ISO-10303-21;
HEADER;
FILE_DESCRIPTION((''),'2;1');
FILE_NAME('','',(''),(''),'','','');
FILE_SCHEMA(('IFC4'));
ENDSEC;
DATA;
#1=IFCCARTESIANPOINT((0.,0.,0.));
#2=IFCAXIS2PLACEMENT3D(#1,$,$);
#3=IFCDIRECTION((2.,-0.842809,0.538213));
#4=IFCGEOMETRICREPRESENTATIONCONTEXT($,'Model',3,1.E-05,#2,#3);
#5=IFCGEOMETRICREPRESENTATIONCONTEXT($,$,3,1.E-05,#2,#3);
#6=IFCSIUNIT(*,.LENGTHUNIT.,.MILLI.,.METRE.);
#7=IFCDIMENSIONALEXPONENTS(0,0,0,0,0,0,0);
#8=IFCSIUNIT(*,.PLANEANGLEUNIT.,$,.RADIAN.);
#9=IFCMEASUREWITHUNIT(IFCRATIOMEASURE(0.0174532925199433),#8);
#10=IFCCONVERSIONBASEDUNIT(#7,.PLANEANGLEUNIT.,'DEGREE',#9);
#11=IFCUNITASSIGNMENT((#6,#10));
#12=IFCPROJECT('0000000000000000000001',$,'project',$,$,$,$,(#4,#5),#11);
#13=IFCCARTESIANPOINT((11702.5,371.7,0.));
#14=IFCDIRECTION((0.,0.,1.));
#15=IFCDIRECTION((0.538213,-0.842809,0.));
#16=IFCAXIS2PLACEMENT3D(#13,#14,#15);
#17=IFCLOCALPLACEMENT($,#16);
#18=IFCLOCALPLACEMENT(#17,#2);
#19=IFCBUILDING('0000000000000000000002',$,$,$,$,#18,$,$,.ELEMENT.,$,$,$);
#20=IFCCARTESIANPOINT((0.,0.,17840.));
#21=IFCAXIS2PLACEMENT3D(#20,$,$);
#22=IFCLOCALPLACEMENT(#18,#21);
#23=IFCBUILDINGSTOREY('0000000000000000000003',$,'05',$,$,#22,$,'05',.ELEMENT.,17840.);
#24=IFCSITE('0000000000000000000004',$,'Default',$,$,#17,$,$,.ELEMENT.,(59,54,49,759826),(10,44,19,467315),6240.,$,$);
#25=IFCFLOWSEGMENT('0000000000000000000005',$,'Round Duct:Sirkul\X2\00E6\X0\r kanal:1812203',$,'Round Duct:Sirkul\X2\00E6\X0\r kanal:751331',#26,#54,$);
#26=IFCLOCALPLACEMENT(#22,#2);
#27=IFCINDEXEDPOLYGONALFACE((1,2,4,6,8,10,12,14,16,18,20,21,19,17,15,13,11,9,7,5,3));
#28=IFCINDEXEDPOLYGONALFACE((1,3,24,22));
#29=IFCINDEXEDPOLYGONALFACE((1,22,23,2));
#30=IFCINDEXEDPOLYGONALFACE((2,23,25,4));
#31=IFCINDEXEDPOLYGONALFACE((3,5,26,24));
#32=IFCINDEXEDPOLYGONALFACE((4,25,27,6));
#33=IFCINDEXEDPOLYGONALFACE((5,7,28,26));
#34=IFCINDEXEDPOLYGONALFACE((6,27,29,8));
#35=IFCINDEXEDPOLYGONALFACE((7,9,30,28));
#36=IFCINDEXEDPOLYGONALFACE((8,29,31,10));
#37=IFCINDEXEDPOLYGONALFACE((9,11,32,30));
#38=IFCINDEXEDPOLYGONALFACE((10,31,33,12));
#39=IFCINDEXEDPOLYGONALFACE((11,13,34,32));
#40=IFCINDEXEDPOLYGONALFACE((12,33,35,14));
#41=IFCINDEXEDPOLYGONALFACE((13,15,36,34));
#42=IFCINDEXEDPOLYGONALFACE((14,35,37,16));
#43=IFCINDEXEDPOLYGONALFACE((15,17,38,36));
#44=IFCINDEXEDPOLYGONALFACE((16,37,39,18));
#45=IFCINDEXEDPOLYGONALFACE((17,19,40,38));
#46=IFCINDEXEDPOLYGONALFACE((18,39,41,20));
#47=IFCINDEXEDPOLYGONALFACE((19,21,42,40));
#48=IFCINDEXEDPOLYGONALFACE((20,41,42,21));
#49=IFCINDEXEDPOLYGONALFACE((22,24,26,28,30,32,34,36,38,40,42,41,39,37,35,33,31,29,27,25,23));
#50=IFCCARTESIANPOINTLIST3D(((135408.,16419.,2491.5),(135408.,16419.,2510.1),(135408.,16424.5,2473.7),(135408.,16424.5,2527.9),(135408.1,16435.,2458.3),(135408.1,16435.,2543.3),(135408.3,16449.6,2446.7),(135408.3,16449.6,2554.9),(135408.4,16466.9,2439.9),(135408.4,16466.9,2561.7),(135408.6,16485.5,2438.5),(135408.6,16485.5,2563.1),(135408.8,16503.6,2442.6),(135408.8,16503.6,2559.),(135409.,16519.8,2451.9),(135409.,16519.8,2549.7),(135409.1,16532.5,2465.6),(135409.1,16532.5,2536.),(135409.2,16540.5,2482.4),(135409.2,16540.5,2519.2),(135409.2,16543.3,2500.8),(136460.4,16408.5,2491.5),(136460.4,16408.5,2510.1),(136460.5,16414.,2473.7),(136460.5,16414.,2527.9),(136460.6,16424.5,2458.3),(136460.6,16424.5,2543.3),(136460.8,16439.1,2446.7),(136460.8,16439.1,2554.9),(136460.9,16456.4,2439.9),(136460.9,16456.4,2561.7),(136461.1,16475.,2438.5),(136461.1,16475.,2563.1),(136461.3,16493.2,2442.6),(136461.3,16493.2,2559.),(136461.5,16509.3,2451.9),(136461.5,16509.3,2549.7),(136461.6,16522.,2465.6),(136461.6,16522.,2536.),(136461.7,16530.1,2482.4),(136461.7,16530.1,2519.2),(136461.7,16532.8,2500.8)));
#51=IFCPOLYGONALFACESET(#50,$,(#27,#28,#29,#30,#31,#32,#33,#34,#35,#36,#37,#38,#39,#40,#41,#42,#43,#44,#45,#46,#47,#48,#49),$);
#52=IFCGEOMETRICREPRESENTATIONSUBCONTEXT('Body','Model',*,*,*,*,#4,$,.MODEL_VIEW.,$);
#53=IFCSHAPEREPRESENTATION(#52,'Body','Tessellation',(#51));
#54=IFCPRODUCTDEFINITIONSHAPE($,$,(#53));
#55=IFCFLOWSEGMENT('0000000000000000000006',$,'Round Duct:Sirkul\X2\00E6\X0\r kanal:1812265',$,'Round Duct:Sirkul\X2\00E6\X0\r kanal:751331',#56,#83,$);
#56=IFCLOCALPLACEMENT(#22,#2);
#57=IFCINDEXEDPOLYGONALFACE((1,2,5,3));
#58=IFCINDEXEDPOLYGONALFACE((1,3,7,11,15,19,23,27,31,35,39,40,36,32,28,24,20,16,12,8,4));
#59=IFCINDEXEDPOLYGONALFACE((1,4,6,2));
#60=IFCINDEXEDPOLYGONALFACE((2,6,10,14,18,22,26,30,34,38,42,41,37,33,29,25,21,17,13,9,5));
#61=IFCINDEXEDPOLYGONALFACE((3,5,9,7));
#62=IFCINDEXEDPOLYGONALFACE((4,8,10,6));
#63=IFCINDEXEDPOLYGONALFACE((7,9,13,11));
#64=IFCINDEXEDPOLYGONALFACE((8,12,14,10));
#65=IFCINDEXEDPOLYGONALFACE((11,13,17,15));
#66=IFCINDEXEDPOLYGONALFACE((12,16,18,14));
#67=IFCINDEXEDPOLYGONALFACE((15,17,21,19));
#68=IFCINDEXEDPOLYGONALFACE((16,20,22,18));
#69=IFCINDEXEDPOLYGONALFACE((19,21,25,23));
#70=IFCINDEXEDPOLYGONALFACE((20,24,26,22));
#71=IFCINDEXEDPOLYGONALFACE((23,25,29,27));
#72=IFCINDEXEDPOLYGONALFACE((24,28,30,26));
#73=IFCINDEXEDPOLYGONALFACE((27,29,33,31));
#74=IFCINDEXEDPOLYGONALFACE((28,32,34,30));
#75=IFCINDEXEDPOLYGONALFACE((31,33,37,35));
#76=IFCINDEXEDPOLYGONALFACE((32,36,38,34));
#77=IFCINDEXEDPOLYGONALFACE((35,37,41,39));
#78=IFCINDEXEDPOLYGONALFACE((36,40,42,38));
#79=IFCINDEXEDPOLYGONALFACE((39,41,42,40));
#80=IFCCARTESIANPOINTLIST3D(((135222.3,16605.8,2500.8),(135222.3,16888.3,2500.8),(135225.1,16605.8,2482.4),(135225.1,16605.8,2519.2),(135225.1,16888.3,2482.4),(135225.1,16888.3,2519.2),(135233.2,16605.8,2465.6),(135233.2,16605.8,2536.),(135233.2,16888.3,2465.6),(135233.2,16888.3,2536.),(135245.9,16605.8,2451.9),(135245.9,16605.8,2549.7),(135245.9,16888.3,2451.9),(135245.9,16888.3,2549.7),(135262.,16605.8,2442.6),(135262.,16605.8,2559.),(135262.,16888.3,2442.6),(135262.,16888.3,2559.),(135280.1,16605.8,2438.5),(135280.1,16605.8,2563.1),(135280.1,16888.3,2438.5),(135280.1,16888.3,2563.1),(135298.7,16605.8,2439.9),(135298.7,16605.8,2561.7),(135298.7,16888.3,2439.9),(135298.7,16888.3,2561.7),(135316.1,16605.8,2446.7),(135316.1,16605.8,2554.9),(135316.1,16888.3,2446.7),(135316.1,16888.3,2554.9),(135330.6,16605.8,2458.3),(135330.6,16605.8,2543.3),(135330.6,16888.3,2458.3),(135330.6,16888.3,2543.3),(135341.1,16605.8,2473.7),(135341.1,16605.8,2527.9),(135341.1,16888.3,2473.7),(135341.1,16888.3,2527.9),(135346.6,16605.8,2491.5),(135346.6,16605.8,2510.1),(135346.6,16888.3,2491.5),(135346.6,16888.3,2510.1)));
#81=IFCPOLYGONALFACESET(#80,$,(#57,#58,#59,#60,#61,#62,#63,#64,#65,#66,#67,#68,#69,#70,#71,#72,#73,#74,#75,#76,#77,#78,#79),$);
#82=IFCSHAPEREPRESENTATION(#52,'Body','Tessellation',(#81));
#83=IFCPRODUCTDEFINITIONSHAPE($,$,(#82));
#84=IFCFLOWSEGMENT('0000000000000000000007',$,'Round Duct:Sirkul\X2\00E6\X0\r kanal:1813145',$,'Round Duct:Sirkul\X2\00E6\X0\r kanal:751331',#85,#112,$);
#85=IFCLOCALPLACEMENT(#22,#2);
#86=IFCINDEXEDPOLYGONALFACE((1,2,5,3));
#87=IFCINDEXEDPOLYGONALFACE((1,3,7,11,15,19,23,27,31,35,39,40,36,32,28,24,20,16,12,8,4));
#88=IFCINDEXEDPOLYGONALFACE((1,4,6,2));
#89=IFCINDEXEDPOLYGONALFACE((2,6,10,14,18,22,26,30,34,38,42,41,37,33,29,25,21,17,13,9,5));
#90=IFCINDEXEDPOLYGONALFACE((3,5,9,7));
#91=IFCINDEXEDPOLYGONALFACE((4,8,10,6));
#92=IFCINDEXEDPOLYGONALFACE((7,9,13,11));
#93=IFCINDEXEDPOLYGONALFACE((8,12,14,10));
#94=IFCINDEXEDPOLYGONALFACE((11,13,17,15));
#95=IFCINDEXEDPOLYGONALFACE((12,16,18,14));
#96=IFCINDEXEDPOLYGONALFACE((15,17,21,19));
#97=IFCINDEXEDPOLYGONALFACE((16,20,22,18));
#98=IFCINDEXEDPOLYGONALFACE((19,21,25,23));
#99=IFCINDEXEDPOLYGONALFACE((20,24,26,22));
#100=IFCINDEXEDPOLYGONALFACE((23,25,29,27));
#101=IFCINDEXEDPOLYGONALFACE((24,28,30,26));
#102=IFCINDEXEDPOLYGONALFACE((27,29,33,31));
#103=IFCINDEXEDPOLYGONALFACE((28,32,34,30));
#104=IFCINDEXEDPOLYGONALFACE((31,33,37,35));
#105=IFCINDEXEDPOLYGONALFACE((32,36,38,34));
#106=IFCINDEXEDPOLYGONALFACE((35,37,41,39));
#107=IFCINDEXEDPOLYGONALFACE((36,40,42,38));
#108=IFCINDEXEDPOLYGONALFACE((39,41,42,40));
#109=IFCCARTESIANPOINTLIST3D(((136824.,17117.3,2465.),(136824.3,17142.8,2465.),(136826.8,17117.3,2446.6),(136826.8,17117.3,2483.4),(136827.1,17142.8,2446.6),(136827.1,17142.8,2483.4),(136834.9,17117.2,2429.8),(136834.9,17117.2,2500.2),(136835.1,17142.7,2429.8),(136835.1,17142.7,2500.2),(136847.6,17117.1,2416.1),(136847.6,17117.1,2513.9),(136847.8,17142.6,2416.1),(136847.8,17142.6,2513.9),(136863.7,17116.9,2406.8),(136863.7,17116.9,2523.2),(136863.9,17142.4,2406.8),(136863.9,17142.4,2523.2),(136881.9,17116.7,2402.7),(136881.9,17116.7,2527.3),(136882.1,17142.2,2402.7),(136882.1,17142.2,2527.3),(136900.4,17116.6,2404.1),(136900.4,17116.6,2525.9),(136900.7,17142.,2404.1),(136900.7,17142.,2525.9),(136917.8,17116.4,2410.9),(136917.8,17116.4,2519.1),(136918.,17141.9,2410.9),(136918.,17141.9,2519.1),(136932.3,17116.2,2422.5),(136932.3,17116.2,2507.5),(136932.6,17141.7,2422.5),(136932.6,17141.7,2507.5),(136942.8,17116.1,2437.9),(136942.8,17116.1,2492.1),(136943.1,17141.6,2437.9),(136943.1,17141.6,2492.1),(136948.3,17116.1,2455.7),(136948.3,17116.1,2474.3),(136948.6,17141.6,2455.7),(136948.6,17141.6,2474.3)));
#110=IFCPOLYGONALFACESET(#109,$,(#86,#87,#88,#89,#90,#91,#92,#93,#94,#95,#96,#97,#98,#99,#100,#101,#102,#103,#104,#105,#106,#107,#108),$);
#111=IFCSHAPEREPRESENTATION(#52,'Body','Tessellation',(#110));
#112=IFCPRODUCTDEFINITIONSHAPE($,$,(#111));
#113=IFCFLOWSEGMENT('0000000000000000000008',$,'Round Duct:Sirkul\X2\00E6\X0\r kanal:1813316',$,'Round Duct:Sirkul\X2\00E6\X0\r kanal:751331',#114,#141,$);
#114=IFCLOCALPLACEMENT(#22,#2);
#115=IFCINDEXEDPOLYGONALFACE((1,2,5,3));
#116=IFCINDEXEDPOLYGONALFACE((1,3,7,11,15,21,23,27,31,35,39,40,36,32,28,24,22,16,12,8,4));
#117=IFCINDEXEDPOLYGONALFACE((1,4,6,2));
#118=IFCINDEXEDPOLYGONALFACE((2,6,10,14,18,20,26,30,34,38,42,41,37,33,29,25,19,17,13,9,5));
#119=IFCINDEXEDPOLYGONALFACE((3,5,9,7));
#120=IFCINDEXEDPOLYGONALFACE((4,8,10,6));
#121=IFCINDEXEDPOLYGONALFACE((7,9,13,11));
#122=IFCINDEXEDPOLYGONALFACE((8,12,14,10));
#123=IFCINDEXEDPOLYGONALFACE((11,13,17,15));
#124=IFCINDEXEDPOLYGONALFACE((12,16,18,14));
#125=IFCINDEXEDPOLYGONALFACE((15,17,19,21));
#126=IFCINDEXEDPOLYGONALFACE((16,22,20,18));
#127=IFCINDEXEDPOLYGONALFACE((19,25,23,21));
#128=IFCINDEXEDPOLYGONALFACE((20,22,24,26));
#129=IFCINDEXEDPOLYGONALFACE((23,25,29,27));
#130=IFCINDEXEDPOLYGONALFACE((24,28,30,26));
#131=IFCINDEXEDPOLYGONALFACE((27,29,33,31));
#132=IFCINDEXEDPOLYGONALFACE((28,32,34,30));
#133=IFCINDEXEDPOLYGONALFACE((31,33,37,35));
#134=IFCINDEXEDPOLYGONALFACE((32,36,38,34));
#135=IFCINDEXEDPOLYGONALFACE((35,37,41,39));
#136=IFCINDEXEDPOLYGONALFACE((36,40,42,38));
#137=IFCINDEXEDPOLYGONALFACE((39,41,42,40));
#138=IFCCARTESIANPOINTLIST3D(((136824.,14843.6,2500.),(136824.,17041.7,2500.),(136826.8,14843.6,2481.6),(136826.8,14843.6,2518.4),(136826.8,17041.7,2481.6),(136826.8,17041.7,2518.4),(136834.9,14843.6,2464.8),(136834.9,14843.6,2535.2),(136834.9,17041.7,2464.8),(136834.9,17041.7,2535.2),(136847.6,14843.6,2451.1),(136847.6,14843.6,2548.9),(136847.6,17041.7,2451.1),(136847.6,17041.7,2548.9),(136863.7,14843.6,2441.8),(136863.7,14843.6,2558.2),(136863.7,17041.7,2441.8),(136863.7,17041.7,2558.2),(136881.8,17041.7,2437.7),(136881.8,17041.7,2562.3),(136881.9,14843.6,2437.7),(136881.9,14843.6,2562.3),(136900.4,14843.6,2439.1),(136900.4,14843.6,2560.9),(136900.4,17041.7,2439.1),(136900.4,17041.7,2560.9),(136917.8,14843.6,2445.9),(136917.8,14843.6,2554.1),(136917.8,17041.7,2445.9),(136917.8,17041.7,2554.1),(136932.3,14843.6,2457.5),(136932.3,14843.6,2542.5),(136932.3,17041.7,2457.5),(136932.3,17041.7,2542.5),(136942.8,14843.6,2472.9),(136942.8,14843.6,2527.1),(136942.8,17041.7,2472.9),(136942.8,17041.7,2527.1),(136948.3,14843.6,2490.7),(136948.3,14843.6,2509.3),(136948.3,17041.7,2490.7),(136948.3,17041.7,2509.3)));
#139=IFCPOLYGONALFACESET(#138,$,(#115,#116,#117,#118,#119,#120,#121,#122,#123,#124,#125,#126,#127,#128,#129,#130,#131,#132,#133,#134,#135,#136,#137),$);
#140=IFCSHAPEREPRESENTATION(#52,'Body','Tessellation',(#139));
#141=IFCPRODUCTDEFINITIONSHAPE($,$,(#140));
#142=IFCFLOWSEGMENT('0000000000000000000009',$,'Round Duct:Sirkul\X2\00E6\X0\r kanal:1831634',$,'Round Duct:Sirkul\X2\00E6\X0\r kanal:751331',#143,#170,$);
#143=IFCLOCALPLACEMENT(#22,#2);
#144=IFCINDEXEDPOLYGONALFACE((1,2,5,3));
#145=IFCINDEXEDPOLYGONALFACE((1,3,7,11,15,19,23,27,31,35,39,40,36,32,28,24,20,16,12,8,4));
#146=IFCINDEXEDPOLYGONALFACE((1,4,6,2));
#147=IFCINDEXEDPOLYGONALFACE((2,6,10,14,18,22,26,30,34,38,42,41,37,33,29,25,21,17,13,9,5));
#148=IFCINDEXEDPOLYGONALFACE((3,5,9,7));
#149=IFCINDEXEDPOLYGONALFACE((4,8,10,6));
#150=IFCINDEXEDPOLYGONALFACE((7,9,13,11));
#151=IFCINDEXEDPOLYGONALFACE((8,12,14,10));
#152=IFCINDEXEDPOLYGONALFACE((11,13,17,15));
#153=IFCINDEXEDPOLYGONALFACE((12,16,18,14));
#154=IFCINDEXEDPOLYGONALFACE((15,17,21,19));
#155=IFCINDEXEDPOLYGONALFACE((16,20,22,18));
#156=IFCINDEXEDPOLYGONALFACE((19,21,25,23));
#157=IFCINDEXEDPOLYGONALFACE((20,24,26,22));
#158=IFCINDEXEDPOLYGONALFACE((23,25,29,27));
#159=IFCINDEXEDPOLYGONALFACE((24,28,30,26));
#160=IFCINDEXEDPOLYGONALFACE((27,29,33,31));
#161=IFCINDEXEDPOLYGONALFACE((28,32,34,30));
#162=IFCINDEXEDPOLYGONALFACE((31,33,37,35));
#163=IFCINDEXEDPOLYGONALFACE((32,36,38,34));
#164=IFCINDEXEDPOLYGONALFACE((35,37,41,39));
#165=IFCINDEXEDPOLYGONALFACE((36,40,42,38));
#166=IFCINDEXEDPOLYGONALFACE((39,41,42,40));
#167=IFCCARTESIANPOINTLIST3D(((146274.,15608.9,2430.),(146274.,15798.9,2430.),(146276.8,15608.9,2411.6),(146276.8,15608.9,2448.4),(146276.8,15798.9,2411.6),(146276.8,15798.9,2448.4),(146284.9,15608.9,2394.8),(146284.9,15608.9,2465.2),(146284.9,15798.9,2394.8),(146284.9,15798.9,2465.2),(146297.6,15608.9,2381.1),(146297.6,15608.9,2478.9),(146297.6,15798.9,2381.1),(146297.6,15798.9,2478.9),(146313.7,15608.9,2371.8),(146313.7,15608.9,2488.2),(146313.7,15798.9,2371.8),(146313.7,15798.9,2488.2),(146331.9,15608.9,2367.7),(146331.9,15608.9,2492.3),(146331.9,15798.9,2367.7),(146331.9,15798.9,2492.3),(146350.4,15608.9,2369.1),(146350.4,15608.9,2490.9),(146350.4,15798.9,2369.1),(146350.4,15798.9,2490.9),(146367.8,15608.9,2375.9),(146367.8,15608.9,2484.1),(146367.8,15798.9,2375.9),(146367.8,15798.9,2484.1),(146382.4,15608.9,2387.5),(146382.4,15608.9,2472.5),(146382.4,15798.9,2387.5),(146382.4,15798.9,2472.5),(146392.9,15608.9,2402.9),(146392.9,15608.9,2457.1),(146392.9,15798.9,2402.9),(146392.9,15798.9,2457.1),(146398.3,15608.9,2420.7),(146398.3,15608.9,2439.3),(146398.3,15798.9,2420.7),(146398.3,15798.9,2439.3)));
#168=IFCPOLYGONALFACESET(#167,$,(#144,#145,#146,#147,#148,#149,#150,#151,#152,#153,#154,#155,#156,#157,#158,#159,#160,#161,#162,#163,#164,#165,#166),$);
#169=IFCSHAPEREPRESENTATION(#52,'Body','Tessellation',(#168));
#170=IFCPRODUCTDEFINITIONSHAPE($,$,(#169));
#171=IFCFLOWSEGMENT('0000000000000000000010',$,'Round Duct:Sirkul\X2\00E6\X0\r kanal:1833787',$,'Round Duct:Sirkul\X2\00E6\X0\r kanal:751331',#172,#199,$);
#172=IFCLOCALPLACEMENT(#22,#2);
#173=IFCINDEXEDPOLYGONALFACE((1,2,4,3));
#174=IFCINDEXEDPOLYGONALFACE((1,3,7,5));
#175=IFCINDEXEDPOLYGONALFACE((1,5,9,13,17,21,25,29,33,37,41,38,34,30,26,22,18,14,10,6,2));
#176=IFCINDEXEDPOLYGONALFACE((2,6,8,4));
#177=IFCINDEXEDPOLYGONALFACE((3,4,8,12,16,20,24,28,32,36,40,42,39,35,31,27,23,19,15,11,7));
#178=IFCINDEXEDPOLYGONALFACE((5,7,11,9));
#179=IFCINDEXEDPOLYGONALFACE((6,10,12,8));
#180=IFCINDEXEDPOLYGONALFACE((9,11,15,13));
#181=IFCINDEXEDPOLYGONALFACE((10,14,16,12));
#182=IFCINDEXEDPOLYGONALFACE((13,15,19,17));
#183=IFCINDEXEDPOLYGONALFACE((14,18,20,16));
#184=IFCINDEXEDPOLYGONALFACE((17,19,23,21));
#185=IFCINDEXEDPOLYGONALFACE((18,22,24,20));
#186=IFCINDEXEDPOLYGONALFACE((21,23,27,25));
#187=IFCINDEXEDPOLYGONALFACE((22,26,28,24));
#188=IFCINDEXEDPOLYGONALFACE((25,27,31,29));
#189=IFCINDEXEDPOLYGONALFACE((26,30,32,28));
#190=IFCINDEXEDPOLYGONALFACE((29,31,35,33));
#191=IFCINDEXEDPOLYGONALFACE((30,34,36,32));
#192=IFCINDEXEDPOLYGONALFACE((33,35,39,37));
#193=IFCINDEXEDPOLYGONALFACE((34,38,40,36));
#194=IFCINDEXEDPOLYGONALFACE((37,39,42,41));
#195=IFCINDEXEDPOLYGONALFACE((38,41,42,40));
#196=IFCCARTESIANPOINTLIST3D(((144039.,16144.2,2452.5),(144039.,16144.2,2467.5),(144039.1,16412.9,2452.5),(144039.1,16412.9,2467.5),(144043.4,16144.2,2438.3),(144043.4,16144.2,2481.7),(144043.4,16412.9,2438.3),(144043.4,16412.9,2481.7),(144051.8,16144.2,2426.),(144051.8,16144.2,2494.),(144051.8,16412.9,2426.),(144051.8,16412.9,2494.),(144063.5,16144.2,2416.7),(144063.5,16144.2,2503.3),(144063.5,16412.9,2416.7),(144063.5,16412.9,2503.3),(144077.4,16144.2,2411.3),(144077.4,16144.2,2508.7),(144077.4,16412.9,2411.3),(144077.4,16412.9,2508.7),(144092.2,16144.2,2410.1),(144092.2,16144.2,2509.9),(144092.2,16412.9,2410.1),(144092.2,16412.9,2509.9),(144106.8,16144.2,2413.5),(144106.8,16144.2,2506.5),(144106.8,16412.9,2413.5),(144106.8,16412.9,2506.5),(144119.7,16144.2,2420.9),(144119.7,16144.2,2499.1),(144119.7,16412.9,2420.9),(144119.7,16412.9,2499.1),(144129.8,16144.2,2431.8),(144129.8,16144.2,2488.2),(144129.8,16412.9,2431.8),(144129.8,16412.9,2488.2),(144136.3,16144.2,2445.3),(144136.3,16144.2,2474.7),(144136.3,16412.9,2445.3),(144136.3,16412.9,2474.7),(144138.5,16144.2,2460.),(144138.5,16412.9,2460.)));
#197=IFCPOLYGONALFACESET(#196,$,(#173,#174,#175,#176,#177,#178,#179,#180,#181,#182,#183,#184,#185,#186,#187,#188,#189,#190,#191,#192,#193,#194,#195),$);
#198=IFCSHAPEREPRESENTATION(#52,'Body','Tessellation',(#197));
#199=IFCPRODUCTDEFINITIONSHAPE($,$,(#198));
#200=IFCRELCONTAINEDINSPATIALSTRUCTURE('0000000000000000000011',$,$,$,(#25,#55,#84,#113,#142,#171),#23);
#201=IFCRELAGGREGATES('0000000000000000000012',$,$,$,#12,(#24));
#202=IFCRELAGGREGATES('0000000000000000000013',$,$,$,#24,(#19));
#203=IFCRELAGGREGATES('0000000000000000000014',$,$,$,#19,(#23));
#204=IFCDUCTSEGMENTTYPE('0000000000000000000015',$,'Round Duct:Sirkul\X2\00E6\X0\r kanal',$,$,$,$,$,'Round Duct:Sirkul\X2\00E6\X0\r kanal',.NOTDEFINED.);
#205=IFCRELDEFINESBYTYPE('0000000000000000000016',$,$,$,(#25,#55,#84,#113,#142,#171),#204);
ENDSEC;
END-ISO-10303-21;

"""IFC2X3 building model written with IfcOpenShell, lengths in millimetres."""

from ifc_helpers import new_model, entity, si_unit, converted_unit, direction, frame, frame_2d, origin, origin_2d_with_axis, place, context, subcontext, project, spatial, circle, extrude, type_object, element, save


model = new_model("IFC2X3")

# Units and contexts
model_context = context("Model", 3, precision=1e-05, world=origin(), true_north=direction((2.0, -0.842809, 0.538213)))
context_of_model = context(None, 3, precision=1e-05, world=origin(), true_north=direction((2.0, -0.842809, 0.538213)))
body_context = subcontext(model_context, "Body", "Model", "MODEL_VIEW")
ifc_project = project(units=[si_unit("LENGTHUNIT", "METRE", prefix="MILLI"), converted_unit("PLANEANGLEUNIT", "DEGREE", entity("IfcRatioMeasure", 0.0174532925199433), si_unit("PLANEANGLEUNIT", "RADIAN"), dimensions=[0, 0, 0, 0, 0, 0, 0])], contexts=[model_context, context_of_model])

# Site, building, storey
site_placement = place(None, frame((11702.5, 371.7, 0.0), z_axis=(0.0, 0.0, 1.0), x_axis=(0.538213, -0.842809, 0.0)))
site = spatial("IfcSite", under=ifc_project, at=site_placement, Name="Default", CompositionType="ELEMENT", RefLatitude=(59, 54, 49, 759826), RefLongitude=(10, 44, 19, 467315), RefElevation=6240.0)
building_placement = place(site_placement, origin())
building = spatial("IfcBuilding", under=site, at=building_placement, CompositionType="ELEMENT")
storey_placement = place(building_placement, frame((0.0, 0.0, 17840.0)))
storey = spatial("IfcBuildingStorey", under=building, at=storey_placement, Name="05", LongName="05", CompositionType="ELEMENT", Elevation=17840.0)

# Flow segments
duct_segment_type_1 = type_object("IfcDuctSegmentType", Name="Round Duct:Sirkulær kanal", ElementType="Round Duct:Sirkulær kanal", PredefinedType="NOTDEFINED")
flow_segment_1_placement = place(storey_placement, origin())
element("IfcFlowSegment", 1, at=flow_segment_1_placement, inside=storey, type_object=duct_segment_type_1, Name="Round Duct:Sirkulær kanal:1812203", ObjectType="Round Duct:Sirkulær kanal:751331", context=body_context, shape_type="SweptSolid", body=[
    extrude(circle(Radius=62.5, at=origin_2d_with_axis()), frame((135408.6, 16480.8, 2500.8), z_axis=(0.99995, -0.009958, 0.0), x_axis=(0.009958, 0.99995, 0.0)), (0.0, 0.0, 1.0), 1052.5),
])
flow_segment_2_placement = place(storey_placement, origin())
element("IfcFlowSegment", 2, at=flow_segment_2_placement, inside=storey, type_object=duct_segment_type_1, Name="Round Duct:Sirkulær kanal:1812265", ObjectType="Round Duct:Sirkulær kanal:751331", context=body_context, shape_type="SweptSolid", body=[
    extrude(circle(Radius=62.5, at=origin_2d_with_axis()), frame((135284.8, 16605.8, 2500.8), z_axis=(0.0, 1.0, 0.0), x_axis=(-1.0, 0.0, 0.0)), (0.0, 0.0, 1.0), 282.5),
])
flow_segment_3_placement = place(storey_placement, origin())
element("IfcFlowSegment", 3, at=flow_segment_3_placement, inside=storey, type_object=duct_segment_type_1, Name="Round Duct:Sirkulær kanal:1813145", ObjectType="Round Duct:Sirkulær kanal:751331", context=body_context, shape_type="SweptSolid", body=[
    extrude(circle(Radius=62.5, at=frame_2d((0.0, 0.0), x_axis=(1.0, 0.0))), frame((136886.5, 17116.7, 2465.0), z_axis=(0.00981, 0.999952, 0.0), x_axis=(-0.999952, 0.00981, 0.0)), (0.0, 0.0, 1.0), 25.5),
])
flow_segment_4_placement = place(storey_placement, origin())
element("IfcFlowSegment", 4, at=flow_segment_4_placement, inside=storey, type_object=duct_segment_type_1, Name="Round Duct:Sirkulær kanal:1813316", ObjectType="Round Duct:Sirkulær kanal:751331", context=body_context, shape_type="SweptSolid", body=[
    extrude(circle(Radius=62.5, at=frame_2d((0.0, 0.0), x_axis=(1.0, 0.0))), frame((136886.5, 14843.6, 2500.0), z_axis=(0.0, 1.0, 0.0), x_axis=(-1.0, 0.0, 0.0)), (0.0, 0.0, 1.0), 2198.0),
])
flow_segment_5_placement = place(storey_placement, origin())
element("IfcFlowSegment", 5, at=flow_segment_5_placement, inside=storey, type_object=duct_segment_type_1, Name="Round Duct:Sirkulær kanal:1831634", ObjectType="Round Duct:Sirkulær kanal:751331", context=body_context, shape_type="SweptSolid", body=[
    extrude(circle(Radius=62.5, at=origin_2d_with_axis()), frame((146336.5, 15608.9, 2430.0), z_axis=(0.0, 1.0, 0.0), x_axis=(-1.0, 0.0, 0.0)), (0.0, 0.0, 1.0), 190.0),
])
flow_segment_6_placement = place(storey_placement, origin())
element("IfcFlowSegment", 6, at=flow_segment_6_placement, inside=storey, type_object=duct_segment_type_1, Name="Round Duct:Sirkulær kanal:1833787", ObjectType="Round Duct:Sirkulær kanal:751331", context=body_context, shape_type="SweptSolid", body=[
    extrude(circle(Radius=50.0, at=frame_2d((0.0, 0.0), x_axis=(1.0, 0.0))), frame((144088.5, 16144.2, 2460.0), z_axis=(0.000037, 1.0, 0.0), x_axis=(1.0, -0.000037, 0.0)), (0.0, 0.0, 1.0), 268.8),
])

save(model, "model.ifc")
